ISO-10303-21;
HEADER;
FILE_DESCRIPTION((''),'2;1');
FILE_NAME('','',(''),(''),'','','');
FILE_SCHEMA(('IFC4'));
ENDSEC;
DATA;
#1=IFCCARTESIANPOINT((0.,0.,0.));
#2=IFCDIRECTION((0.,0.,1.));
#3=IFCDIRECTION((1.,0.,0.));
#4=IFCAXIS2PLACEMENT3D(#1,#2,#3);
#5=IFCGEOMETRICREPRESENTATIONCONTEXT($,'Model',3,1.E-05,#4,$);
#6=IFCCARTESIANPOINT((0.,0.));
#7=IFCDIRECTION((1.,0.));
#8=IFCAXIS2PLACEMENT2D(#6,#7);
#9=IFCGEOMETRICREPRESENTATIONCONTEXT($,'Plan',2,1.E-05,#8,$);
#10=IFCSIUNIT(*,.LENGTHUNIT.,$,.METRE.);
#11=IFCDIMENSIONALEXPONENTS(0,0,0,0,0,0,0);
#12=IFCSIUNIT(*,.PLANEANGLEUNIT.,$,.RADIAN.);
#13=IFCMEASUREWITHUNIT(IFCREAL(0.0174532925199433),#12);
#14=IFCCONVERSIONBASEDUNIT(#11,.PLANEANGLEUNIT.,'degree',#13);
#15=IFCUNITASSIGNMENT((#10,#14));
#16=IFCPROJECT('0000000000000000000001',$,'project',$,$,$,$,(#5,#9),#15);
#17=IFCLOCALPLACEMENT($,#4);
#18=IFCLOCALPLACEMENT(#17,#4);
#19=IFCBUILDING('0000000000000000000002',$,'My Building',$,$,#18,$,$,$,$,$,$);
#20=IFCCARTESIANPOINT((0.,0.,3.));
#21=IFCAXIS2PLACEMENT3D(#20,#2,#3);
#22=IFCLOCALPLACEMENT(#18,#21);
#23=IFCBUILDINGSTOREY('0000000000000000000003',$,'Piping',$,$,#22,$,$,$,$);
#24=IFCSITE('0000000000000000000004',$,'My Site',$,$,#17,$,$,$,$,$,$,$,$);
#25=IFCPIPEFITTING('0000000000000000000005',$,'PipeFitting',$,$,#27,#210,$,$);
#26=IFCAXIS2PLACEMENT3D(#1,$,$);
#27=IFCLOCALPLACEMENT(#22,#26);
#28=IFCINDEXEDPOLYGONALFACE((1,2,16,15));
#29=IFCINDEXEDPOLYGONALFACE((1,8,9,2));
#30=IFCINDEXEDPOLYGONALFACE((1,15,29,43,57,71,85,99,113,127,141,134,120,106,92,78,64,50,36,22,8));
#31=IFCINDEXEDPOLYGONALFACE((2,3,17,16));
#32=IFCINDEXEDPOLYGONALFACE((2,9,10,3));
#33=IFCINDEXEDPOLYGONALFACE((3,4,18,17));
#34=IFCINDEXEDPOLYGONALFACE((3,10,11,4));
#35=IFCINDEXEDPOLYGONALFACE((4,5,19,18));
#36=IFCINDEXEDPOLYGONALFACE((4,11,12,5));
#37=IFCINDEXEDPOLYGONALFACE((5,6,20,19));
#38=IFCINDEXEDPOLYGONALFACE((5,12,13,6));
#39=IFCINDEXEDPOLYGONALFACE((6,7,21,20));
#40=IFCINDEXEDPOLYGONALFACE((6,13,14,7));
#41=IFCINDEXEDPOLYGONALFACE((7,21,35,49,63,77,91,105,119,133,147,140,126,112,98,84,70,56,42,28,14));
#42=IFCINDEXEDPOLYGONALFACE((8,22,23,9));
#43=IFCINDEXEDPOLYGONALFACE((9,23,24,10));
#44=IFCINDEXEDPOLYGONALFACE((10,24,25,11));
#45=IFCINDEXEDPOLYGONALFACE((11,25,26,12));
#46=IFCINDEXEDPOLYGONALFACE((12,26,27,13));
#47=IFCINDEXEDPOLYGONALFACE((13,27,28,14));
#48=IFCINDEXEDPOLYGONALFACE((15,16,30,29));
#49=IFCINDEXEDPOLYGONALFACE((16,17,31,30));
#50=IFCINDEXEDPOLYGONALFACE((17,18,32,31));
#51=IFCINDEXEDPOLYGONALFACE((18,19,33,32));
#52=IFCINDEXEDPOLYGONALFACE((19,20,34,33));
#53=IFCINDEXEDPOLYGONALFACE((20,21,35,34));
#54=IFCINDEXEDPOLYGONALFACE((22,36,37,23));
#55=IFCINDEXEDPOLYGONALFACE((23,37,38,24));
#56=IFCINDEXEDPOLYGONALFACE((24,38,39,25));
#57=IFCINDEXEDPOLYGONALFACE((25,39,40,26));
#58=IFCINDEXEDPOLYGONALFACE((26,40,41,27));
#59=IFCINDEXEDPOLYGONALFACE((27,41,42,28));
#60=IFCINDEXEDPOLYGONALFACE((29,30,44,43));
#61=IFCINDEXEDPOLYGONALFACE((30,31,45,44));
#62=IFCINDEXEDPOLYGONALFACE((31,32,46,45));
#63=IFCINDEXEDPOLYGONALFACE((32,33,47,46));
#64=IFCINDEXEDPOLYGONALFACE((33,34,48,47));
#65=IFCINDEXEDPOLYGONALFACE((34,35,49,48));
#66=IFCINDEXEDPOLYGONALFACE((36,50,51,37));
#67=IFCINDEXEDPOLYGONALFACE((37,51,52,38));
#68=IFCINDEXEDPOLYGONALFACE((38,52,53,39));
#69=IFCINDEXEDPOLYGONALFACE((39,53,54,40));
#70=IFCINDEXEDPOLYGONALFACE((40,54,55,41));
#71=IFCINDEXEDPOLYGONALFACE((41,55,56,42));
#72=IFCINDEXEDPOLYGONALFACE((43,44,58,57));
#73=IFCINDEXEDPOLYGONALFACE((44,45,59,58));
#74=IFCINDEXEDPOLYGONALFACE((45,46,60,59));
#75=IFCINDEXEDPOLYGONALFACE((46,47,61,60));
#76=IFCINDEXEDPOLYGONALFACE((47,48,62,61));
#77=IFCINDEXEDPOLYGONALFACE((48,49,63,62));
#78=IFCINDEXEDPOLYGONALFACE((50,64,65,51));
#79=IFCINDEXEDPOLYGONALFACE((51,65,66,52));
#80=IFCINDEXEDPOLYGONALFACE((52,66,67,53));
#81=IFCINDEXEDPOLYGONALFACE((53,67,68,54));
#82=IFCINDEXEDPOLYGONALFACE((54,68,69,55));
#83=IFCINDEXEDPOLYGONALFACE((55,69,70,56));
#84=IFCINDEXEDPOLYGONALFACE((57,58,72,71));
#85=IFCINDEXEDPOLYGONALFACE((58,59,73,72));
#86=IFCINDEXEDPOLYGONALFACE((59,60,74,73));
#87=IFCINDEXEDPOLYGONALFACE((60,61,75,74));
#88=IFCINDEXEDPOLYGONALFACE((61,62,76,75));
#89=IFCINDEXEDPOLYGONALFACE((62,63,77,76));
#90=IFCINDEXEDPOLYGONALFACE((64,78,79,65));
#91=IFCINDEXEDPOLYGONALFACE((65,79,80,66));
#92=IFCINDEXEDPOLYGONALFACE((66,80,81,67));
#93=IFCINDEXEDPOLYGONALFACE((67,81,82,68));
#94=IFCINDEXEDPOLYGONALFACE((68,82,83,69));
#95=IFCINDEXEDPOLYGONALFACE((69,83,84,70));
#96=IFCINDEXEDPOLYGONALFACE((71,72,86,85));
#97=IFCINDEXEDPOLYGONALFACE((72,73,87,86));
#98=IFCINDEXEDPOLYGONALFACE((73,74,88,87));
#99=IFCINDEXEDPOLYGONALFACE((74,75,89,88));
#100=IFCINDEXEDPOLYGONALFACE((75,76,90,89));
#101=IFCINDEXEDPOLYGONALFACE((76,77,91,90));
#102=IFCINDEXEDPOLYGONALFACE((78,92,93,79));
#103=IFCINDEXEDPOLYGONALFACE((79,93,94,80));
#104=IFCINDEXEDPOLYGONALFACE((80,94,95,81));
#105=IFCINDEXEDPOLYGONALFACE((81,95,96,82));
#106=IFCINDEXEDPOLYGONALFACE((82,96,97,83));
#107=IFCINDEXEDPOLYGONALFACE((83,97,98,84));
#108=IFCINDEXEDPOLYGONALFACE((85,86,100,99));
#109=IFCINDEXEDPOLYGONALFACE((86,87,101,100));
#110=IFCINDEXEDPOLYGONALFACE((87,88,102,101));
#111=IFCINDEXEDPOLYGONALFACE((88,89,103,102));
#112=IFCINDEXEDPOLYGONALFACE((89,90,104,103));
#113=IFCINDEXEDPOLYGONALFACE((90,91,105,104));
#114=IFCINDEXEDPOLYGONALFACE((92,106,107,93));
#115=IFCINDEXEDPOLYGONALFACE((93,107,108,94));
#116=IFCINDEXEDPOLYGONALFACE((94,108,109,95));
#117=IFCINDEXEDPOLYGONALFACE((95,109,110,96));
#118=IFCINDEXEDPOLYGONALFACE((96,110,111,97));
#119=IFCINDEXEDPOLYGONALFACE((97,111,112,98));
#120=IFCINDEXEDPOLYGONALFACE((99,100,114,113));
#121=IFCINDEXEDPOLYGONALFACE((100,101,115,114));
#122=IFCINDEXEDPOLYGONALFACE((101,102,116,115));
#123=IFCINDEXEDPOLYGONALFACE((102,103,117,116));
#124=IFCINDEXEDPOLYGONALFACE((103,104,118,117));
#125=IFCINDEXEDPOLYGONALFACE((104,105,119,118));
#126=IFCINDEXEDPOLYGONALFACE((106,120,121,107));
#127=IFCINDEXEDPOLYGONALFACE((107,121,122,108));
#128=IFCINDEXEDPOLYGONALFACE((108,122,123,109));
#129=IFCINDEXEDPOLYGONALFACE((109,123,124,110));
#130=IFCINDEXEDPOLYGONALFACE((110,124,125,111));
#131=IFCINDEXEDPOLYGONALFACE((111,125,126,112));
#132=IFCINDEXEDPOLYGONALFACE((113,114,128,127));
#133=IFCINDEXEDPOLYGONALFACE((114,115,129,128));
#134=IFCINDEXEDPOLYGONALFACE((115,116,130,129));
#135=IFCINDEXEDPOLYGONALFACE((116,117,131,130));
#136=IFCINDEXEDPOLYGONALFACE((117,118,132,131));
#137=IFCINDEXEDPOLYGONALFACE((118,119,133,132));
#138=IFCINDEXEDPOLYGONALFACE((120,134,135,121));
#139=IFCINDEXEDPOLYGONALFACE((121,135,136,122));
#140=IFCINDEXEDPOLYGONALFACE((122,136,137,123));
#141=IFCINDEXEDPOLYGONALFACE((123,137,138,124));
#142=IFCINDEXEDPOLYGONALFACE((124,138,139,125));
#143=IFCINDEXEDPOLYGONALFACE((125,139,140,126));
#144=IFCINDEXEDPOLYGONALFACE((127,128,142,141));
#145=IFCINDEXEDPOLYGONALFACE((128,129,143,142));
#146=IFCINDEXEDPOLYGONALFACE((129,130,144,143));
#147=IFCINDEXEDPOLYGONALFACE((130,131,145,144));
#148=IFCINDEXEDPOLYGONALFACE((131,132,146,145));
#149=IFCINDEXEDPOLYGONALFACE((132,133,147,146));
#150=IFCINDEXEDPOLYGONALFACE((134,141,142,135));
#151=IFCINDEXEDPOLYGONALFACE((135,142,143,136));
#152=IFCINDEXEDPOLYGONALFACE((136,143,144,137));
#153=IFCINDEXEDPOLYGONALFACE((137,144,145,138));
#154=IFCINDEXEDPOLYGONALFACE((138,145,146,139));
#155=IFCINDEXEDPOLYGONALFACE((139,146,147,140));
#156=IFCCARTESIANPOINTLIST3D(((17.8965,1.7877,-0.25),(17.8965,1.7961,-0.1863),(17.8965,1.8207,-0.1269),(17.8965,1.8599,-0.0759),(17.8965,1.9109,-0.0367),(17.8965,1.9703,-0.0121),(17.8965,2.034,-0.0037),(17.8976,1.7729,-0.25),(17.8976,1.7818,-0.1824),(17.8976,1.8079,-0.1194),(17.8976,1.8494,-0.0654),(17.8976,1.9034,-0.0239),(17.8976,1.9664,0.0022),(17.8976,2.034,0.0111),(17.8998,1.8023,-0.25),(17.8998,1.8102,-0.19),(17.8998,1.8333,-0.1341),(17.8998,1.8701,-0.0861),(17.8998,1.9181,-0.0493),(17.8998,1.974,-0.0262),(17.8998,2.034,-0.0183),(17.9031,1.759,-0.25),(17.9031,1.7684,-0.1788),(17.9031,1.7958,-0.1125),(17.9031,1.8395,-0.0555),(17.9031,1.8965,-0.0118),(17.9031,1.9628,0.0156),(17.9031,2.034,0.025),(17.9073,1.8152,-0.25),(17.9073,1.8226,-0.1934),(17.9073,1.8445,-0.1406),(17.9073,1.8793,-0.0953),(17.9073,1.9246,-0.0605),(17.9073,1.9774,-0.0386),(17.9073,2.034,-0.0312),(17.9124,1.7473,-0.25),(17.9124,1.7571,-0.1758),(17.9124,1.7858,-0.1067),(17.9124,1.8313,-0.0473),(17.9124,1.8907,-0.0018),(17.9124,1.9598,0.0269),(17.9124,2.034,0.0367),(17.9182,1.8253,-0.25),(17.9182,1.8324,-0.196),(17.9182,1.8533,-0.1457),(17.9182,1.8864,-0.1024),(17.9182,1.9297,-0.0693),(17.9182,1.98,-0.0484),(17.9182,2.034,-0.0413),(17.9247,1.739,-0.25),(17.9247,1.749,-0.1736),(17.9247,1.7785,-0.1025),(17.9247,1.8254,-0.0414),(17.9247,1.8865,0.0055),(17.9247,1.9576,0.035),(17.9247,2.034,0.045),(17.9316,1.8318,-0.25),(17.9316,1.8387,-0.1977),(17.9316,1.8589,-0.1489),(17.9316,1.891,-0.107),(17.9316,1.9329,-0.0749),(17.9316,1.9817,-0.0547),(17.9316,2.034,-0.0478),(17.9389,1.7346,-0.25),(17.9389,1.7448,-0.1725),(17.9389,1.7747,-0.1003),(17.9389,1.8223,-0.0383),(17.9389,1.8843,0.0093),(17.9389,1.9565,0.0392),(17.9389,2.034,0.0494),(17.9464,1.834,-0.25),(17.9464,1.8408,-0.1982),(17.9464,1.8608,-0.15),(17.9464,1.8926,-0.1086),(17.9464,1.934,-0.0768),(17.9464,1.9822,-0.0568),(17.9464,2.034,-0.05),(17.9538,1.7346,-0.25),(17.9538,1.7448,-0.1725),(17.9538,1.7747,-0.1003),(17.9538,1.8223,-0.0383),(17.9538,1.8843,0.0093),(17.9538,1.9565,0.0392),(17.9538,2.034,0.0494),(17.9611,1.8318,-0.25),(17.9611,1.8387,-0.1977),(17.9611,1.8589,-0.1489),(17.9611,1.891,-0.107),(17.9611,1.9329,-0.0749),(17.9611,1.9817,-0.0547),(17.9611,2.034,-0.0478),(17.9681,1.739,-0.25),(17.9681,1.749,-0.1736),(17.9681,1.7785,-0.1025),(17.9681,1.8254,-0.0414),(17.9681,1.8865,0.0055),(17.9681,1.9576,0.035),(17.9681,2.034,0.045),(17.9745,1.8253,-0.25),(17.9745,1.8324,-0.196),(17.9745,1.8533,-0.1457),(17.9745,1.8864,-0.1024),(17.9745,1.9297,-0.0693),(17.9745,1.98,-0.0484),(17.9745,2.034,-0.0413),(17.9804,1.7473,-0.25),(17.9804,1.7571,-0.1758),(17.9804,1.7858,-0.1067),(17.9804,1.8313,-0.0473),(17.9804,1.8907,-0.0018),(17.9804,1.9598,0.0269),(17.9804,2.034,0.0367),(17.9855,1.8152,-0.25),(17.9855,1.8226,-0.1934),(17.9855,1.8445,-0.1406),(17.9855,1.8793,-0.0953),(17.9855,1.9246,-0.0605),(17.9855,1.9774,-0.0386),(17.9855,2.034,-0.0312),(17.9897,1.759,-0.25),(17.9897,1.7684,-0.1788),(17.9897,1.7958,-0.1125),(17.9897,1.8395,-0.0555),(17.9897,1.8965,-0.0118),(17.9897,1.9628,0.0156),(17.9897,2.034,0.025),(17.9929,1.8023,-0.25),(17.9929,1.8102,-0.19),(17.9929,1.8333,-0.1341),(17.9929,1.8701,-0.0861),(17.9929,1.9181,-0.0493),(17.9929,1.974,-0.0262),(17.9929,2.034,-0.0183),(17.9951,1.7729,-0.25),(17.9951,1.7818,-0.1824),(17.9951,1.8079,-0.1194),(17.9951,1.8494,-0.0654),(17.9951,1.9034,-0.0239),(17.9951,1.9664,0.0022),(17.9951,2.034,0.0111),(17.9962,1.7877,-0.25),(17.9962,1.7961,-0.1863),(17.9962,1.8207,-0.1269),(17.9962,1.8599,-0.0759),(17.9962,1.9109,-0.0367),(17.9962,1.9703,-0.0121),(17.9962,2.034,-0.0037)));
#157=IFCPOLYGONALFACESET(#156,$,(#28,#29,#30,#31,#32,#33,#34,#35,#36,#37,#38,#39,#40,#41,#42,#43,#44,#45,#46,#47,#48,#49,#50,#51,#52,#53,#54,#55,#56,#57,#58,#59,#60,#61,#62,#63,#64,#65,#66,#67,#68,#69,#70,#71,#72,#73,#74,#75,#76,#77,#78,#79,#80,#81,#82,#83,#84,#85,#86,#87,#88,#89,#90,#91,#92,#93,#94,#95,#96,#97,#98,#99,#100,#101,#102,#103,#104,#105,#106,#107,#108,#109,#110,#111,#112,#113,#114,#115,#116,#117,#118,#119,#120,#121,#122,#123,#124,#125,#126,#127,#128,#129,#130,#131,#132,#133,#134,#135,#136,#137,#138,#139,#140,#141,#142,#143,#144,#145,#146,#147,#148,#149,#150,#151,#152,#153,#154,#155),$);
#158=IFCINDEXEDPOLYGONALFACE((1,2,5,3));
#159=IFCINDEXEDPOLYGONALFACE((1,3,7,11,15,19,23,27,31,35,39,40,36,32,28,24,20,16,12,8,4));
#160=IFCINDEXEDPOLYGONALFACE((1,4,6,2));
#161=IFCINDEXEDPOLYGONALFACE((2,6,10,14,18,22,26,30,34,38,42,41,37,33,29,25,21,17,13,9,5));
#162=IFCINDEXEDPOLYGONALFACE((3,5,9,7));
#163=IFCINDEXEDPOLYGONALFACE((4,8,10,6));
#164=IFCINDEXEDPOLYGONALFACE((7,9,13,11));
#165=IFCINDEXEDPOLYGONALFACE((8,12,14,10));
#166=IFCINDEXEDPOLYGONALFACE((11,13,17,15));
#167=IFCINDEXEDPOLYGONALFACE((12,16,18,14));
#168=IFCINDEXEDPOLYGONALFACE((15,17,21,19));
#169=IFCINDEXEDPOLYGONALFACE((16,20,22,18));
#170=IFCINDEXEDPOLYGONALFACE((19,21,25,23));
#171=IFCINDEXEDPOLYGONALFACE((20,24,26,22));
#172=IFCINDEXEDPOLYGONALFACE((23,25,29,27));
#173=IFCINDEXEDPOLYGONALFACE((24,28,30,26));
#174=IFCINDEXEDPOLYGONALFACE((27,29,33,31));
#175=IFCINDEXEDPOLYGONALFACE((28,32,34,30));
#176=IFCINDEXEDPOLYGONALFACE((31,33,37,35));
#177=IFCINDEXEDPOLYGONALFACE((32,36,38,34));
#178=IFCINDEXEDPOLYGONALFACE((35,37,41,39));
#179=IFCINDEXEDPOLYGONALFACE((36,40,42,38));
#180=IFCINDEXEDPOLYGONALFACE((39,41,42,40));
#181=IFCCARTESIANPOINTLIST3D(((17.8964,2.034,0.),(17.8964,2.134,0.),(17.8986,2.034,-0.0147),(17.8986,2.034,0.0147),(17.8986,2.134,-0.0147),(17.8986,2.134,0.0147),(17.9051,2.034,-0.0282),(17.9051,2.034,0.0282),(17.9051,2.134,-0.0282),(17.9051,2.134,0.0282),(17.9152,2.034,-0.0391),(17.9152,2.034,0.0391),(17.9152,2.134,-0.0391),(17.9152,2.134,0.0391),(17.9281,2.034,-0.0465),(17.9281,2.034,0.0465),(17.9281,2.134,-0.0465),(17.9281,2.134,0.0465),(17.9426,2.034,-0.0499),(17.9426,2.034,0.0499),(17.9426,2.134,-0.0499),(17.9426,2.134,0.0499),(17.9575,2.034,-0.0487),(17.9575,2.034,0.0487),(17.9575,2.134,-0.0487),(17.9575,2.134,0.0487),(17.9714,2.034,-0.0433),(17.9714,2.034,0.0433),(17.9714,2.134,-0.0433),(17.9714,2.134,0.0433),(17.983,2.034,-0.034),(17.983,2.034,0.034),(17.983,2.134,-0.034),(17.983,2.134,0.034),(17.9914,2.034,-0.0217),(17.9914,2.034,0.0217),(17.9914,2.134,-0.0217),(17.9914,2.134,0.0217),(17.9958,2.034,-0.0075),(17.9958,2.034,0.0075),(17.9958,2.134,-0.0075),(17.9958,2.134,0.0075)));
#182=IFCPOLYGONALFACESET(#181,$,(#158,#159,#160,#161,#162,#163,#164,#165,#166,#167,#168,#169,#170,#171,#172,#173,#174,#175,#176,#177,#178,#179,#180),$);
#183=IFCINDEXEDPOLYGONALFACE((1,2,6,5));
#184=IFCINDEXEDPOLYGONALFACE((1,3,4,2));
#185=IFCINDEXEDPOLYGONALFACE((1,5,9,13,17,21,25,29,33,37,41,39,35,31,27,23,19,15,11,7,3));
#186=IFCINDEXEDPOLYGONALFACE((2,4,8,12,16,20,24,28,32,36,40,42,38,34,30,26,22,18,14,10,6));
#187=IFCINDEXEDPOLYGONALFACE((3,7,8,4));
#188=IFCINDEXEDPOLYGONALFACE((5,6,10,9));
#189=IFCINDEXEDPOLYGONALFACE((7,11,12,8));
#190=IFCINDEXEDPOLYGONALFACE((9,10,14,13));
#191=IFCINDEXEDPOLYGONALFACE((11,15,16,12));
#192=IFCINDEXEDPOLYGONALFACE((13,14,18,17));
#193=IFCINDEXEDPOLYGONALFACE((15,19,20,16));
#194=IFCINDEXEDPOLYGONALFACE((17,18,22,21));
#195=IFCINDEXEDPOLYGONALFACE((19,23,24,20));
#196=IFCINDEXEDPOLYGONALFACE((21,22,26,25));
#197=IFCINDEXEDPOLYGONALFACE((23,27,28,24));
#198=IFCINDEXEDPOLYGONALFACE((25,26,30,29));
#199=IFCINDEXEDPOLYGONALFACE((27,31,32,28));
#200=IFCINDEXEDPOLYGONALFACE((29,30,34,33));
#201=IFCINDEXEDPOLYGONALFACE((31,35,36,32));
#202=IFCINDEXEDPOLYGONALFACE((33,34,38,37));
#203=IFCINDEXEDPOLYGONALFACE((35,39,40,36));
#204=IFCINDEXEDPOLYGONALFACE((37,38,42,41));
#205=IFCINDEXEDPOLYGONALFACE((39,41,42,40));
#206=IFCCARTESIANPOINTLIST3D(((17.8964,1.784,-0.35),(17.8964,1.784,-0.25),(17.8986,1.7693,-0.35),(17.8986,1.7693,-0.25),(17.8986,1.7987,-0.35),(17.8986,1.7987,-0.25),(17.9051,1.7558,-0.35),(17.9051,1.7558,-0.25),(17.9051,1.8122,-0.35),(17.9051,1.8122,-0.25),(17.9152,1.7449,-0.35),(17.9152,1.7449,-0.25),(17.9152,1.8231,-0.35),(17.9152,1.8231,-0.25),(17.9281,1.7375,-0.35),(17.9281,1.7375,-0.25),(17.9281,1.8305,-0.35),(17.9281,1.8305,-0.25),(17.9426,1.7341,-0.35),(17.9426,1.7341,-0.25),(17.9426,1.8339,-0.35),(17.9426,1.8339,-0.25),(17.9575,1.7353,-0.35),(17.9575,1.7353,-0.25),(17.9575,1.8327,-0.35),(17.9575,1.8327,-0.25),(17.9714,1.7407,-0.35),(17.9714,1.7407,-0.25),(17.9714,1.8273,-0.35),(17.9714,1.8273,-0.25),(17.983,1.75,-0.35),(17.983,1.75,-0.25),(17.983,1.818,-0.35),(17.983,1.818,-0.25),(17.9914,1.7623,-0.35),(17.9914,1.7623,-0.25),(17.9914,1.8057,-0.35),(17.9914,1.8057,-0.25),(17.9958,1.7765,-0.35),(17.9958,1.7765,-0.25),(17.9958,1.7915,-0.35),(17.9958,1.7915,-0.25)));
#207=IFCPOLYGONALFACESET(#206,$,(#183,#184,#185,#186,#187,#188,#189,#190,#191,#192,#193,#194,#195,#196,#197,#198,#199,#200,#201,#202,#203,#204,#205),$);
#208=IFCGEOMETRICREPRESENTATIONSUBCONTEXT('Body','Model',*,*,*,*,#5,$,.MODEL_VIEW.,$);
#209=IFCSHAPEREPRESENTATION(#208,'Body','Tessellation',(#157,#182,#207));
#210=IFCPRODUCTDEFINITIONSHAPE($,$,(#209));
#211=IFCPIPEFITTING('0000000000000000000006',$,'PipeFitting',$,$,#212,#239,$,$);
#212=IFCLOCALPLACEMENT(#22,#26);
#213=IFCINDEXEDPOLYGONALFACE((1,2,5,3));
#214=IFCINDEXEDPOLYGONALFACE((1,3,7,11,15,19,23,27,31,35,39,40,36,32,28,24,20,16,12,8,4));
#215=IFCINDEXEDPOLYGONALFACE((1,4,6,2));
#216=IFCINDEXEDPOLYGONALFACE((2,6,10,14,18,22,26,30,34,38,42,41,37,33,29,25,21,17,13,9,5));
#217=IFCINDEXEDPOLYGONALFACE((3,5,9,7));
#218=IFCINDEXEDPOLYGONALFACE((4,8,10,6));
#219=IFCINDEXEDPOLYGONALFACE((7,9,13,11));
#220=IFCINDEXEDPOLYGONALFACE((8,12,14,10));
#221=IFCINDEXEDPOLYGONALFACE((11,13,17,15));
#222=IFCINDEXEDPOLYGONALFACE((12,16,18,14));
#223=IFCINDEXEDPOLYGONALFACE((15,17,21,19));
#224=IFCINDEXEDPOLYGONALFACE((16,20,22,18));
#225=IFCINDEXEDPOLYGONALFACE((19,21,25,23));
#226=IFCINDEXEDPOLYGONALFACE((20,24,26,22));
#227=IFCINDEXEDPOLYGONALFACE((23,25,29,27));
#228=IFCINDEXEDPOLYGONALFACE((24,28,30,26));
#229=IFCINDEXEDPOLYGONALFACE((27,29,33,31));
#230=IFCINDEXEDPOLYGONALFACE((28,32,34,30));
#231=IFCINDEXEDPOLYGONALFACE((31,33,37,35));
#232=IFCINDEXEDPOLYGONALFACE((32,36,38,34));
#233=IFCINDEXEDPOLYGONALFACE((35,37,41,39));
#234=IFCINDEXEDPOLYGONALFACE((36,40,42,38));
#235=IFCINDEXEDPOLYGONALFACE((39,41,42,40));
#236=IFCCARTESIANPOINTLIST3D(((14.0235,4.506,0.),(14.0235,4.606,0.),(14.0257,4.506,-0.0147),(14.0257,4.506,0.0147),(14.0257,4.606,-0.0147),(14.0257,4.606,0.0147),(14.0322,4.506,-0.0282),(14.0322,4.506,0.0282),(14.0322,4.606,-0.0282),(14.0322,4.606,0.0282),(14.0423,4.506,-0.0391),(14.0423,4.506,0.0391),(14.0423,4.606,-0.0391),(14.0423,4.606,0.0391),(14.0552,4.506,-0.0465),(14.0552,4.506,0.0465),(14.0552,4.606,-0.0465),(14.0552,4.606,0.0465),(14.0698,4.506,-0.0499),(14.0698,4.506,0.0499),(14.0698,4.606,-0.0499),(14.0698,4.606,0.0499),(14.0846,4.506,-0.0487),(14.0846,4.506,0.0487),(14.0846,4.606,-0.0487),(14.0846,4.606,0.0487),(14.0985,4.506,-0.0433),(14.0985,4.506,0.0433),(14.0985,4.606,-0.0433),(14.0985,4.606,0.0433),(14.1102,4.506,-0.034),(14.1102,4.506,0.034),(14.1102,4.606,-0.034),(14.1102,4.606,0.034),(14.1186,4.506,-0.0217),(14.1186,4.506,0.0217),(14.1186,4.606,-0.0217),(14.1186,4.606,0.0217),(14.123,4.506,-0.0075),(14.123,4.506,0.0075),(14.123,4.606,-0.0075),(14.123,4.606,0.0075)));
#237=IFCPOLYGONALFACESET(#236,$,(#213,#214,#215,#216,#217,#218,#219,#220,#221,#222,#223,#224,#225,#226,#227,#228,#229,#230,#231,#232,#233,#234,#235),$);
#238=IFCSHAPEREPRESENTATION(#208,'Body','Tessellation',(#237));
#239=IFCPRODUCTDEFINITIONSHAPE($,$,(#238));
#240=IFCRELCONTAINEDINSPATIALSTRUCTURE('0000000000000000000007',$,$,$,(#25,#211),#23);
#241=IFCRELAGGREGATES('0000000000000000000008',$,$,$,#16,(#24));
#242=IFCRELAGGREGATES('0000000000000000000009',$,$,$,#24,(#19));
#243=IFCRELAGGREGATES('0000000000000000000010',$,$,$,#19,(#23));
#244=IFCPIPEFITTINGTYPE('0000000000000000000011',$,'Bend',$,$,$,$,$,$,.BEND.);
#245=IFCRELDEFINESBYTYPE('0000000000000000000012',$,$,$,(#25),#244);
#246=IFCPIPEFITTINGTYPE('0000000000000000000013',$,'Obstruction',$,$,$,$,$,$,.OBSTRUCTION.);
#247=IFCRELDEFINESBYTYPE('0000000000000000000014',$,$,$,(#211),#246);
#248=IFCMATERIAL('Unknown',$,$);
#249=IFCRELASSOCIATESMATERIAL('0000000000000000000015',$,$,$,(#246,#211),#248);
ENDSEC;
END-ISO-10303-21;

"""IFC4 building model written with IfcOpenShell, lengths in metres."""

from ifc_helpers import new_model, entity, si_unit, converted_unit, frame, origin_with_axes, origin_2d_with_axis, place, context, subcontext, project, spatial, circle, extrude, source, transform, mapped, material, material_profile, profile_set, profile_usage, type_object, type_shapes, element, save


model = new_model("IFC4")

# Units and contexts
model_context = context("Model", 3, precision=1e-05, world=origin_with_axes())
plan_context = context("Plan", 2, precision=1e-05, world=origin_2d_with_axis())
body_context = subcontext(model_context, "Body", "Model", "MODEL_VIEW")
ifc_project = project(units=[si_unit("LENGTHUNIT", "METRE"), converted_unit("PLANEANGLEUNIT", "degree", entity("IfcReal", 0.0174532925199433), si_unit("PLANEANGLEUNIT", "RADIAN"), dimensions=[0, 0, 0, 0, 0, 0, 0])], contexts=[model_context, plan_context])

# Site, building, storey
site_placement = place(None, origin_with_axes())
site = spatial("IfcSite", under=ifc_project, at=site_placement, Name="My Site")
building_placement = place(site_placement, origin_with_axes())
building = spatial("IfcBuilding", under=site, at=building_placement, Name="My Building")
storey_placement = place(building_placement, frame((0.0, 0.0, 3.0), z_axis=(0.0, 0.0, 1.0), x_axis=(1.0, 0.0, 0.0)))
storey = spatial("IfcBuildingStorey", under=building, at=storey_placement, Name="Piping")

# Shared definitions
ifc_material = material(Name="Unknown")

# Pipe fittings
pipe_fitting_type_1 = type_object("IfcPipeFittingType", Name="Bend", PredefinedType="BEND")
shared_shape = source(origin_with_axes(), body_context, "Body", "SolidModel", [
    entity("IfcSweptDiskSolid", entity("IfcIndexedPolyCurve", entity("IfcCartesianPointList3D", [[0.0, 0.0, -0.1], [0.0, -0.0732, -0.2768], [0.0, -0.25, -0.35]]), [entity("IfcArcIndex", [1, 2, 3])]), 0.05),
    extrude(circle(Radius=0.05), origin_with_axes(), (0.0, 0.0, -1.0), 0.1),
    extrude(circle(Radius=0.05), frame((0.0, -0.25, -0.35), z_axis=(0.0, -1.0, 0.0), x_axis=(1.0, 0.0, 0.0)), (0.0, 0.0, 1.0), 0.1),
])
type_shapes(pipe_fitting_type_1, [shared_shape])
for number, where, z_axis, x_axis, name in (
    (1, (17.9464, 2.134, 0.0), (0.0, 1.0, 0.0), (-1.0, 0.0, 0.0), "PipeFitting"),
):
    element("IfcPipeFitting", number, at=place(storey_placement, frame(where, z_axis=z_axis, x_axis=x_axis)), inside=storey, type_object=pipe_fitting_type_1, Name=name, context=body_context, shape_type="MappedRepresentation", body=[
        mapped(shared_shape, transform((0.0, 0.0, 0.0), x_axis=(1.0, 0.0, 0.0), y_axis=(0.0, 1.0, 0.0), z_axis=(0.0, 0.0, 1.0), scale=1.0)),
    ])
ifc_material_profile_1 = material_profile(ifc_material, circle(Radius=0.05))
ifc_profile_set_1 = profile_set([ifc_material_profile_1])
ifc_profile_usage_1 = profile_usage(ifc_profile_set_1, cardinal=5)
pipe_fitting_type_2 = type_object("IfcPipeFittingType", Name="Obstruction", PredefinedType="OBSTRUCTION", material=ifc_profile_set_1)
pipe_fitting_1_placement = place(storey_placement, frame((14.0735, 4.506, 0.0), z_axis=(0.0, 1.0, 0.0), x_axis=(-1.0, 0.0, 0.0)))
element("IfcPipeFitting", 2, at=pipe_fitting_1_placement, inside=storey, type_object=pipe_fitting_type_2, material=ifc_profile_usage_1, Name="PipeFitting", context=body_context, shape_type="SweptSolid", body=[
    extrude(circle(Radius=0.05), origin_with_axes(), (0.0, 0.0, 1.0), 0.1),
])

save(model, "model.ifc")
